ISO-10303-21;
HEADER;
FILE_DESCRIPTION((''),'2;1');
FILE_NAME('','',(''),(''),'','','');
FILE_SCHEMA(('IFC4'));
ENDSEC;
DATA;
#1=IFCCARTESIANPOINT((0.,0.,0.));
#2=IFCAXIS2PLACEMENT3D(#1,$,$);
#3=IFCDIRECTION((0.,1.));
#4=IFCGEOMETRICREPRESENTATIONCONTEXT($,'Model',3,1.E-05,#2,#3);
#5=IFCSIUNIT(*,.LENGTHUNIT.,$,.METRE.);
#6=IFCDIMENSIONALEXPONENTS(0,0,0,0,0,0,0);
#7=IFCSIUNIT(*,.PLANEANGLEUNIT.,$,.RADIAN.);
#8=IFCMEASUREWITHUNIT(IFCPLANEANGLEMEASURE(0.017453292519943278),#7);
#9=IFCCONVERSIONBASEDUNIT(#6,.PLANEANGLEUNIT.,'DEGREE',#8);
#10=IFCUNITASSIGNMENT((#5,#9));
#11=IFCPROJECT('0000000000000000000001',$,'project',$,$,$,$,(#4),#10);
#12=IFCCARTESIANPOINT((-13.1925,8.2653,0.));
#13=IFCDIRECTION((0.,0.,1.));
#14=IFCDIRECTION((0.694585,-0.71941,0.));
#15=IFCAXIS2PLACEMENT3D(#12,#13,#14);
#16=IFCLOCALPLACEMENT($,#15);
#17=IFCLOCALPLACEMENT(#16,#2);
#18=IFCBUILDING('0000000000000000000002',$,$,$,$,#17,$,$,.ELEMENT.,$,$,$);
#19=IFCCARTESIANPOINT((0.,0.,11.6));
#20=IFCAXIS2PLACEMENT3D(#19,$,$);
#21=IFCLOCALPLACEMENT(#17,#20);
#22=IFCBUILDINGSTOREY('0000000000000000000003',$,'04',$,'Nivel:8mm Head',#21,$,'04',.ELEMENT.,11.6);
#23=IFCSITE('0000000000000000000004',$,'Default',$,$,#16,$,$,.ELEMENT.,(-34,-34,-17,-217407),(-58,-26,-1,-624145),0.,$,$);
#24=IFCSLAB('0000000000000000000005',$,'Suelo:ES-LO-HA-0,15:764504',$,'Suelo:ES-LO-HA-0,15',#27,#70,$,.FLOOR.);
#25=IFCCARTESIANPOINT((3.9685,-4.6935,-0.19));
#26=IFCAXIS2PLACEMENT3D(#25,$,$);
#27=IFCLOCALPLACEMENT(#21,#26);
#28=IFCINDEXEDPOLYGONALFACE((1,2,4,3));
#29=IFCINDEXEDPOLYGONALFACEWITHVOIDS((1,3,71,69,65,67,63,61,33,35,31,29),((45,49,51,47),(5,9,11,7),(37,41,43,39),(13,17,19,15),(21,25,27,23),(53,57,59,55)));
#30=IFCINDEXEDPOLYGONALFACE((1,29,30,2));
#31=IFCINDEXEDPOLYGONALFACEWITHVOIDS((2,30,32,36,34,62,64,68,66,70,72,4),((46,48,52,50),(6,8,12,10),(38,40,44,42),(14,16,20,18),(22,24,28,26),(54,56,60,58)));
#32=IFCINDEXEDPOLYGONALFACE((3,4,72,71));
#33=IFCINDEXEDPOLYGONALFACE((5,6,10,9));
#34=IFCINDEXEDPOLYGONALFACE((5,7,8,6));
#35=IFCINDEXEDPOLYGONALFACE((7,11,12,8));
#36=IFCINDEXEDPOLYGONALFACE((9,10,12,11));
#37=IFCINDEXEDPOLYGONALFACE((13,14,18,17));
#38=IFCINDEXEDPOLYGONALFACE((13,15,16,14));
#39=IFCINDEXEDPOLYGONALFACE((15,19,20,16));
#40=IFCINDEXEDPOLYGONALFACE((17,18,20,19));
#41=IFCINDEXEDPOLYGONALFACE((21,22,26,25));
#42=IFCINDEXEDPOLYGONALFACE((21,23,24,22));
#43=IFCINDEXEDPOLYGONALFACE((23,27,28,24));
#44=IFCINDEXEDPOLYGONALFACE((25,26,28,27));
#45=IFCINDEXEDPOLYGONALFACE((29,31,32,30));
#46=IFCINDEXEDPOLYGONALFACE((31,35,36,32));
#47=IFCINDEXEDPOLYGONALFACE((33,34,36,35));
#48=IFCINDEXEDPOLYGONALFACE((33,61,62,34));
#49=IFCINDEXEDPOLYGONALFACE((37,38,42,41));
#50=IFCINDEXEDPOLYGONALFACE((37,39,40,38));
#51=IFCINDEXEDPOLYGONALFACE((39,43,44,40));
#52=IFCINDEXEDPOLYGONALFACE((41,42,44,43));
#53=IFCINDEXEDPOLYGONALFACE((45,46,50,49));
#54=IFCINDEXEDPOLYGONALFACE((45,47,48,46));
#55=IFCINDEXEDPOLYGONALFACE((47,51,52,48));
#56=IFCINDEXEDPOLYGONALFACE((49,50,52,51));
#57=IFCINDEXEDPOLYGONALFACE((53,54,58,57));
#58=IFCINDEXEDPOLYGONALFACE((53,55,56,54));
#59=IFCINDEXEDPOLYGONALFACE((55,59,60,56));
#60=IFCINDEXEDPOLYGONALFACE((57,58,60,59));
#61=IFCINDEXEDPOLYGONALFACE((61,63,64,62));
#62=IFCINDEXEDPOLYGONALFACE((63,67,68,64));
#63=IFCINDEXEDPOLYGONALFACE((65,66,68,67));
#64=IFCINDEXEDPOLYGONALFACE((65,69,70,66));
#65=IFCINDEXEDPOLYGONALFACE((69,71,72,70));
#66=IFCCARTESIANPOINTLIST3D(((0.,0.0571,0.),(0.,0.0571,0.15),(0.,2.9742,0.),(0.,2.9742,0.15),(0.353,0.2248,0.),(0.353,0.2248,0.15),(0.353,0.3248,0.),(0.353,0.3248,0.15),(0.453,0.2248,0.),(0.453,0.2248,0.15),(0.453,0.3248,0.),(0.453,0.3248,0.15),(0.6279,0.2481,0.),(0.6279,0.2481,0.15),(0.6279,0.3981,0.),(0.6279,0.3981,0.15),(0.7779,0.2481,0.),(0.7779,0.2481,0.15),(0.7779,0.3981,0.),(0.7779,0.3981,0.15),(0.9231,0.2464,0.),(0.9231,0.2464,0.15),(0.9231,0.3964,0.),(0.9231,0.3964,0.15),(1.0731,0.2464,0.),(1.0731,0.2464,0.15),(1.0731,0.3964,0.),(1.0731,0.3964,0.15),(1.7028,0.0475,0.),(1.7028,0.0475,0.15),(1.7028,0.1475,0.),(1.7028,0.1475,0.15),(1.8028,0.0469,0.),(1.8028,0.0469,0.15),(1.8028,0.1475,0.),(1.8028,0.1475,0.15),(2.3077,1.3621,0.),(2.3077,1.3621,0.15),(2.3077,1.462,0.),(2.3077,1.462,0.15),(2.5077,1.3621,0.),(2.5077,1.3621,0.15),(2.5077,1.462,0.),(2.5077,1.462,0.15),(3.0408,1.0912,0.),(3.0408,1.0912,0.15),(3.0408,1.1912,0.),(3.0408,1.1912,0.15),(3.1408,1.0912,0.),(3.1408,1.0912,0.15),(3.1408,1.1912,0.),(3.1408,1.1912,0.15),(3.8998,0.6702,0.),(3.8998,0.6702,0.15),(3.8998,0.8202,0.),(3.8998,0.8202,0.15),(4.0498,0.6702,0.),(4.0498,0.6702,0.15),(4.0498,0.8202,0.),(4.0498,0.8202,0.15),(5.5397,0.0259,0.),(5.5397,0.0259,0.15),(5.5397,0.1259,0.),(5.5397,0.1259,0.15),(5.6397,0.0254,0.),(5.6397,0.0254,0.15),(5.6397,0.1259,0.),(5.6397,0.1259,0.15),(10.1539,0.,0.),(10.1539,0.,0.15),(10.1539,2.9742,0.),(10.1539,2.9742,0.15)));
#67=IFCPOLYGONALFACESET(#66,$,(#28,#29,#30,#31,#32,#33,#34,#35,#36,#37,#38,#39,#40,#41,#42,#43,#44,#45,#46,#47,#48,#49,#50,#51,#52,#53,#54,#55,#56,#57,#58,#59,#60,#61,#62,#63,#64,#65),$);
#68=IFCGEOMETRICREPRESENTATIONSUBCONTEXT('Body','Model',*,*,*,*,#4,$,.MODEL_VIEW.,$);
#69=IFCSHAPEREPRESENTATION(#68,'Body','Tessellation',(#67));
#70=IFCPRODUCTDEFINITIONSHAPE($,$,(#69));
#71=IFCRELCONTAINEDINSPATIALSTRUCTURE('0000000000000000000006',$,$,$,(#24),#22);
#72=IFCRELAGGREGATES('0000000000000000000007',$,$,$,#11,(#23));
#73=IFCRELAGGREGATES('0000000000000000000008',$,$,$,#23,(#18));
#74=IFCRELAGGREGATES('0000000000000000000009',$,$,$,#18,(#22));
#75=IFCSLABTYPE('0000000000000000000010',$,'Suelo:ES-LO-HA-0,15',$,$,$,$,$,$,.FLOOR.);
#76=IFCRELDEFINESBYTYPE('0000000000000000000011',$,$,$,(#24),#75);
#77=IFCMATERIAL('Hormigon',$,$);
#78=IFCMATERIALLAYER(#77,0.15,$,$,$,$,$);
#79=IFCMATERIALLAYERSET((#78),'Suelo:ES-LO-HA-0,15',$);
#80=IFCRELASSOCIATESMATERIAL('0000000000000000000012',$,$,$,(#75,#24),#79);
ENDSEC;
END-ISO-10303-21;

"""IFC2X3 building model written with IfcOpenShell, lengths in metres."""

from ifc_helpers import new_model, entity, si_unit, converted_unit, direction, frame, frame_2d, origin, origin_2d_with_axis, place, context, subcontext, project, spatial, polyline, rectangle, outline, extrude, material, layer, layer_set, layer_usage, type_object, element, save


model = new_model("IFC2X3")

# Units and contexts
model_context = context("Model", 3, precision=1e-05, world=origin(), true_north=direction((0.0, 1.0)))
body_context = subcontext(model_context, "Body", "Model", "MODEL_VIEW")
ifc_project = project(units=[si_unit("LENGTHUNIT", "METRE"), converted_unit("PLANEANGLEUNIT", "DEGREE", entity("IfcPlaneAngleMeasure", 0.017453292519943278), si_unit("PLANEANGLEUNIT", "RADIAN"), dimensions=[0, 0, 0, 0, 0, 0, 0])], contexts=[model_context])

# Site, building, storey
site_placement = place(None, frame((-13.1925, 8.2653, 0.0), z_axis=(0.0, 0.0, 1.0), x_axis=(0.694585, -0.71941, 0.0)))
site = spatial("IfcSite", under=ifc_project, at=site_placement, Name="Default", CompositionType="ELEMENT", RefLatitude=(-34, -34, -17, -217407), RefLongitude=(-58, -26, -1, -624145), RefElevation=0.0)
building_placement = place(site_placement, origin())
building = spatial("IfcBuilding", under=site, at=building_placement, CompositionType="ELEMENT")
storey_placement = place(building_placement, frame((0.0, 0.0, 11.6)))
storey = spatial("IfcBuildingStorey", under=building, at=storey_placement, Name="04", ObjectType="Nivel:8mm Head", LongName="04", CompositionType="ELEMENT", Elevation=11.6)

# Shared definitions
ifc_material_1 = material(Name="Hormigon")

# Slab, openings
ifc_layer = layer(ifc_material_1, 0.15)
ifc_layer_set = layer_set([ifc_layer], Name="Suelo:ES-LO-HA-0,15")
ifc_layer_usage = layer_usage(ifc_layer_set, "AXIS3", "POSITIVE", 0.0)
slab_type = type_object("IfcSlabType", Name="Suelo:ES-LO-HA-0,15", PredefinedType="FLOOR", material=ifc_layer_set)
slab_placement = place(storey_placement, frame((3.9685, -4.6935, -0.19)))
slab = element("IfcSlab", 1, at=slab_placement, inside=storey, type_object=slab_type, material=ifc_layer_usage, Name="Suelo:ES-LO-HA-0,15:764504", ObjectType="Suelo:ES-LO-HA-0,15", PredefinedType="FLOOR", context=body_context, shape_type="SweptSolid", body=[
    extrude(outline(polyline([(-5.077, 1.4871), (-5.077, -1.4871), (-0.5627, -1.4617), (-0.5627, -1.3612), (-0.4627, -1.3612), (-0.4627, -1.4612), (3.2742, -1.4402), (3.2742, -1.3396), (3.3742, -1.3396), (3.3742, -1.4396), (5.077, -1.43), (5.077, 1.4871), (-5.077, 1.4871)])), frame((5.077, 1.4871, 0.15), z_axis=(0.0, 0.0, -1.0), x_axis=(-1.0, 0.0, 0.0)), (0.0, 0.0, 1.0), 0.15),
])
opening_1_placement = place(slab_placement, origin())
element("IfcOpeningElement", 2, at=opening_1_placement, cuts=slab, ObjectType="Opening", context=body_context, shape_type="SweptSolid", body=[
    extrude(rectangle(XDim=0.1, YDim=0.2, at=origin_2d_with_axis()), frame((2.4077, 1.412, 0.15), z_axis=(0.0, 0.0, -1.0), x_axis=(0.0, -1.0, 0.0)), (0.0, 0.0, 1.0), 0.15),
])
opening_2_placement = place(slab_placement, origin())
element("IfcOpeningElement", 3, at=opening_2_placement, cuts=slab, ObjectType="Opening", context=body_context, shape_type="SweptSolid", body=[
    extrude(rectangle(XDim=0.1, YDim=0.1, at=frame_2d((0.0, 0.0), x_axis=(1.0, 0.0))), frame((3.0908, 1.1412, 0.15), z_axis=(0.0, 0.0, -1.0), x_axis=(0.0, -1.0, 0.0)), (0.0, 0.0, 1.0), 0.15),
])
opening_3_placement = place(slab_placement, origin())
element("IfcOpeningElement", 4, at=opening_3_placement, cuts=slab, ObjectType="Opening", context=body_context, shape_type="SweptSolid", body=[
    extrude(rectangle(XDim=0.15, YDim=0.15, at=frame_2d((0.0, 0.0), x_axis=(1.0, 0.0))), frame((3.9748, 0.7452, 0.15), z_axis=(0.0, 0.0, -1.0), x_axis=(0.0, -1.0, 0.0)), (0.0, 0.0, 1.0), 0.15),
])
opening_4_placement = place(slab_placement, origin())
element("IfcOpeningElement", 5, at=opening_4_placement, cuts=slab, ObjectType="Opening", context=body_context, shape_type="SweptSolid", body=[
    extrude(rectangle(XDim=0.15, YDim=0.15, at=frame_2d((0.0, 0.0), x_axis=(1.0, 0.0))), frame((0.9981, 0.3214, 0.15), z_axis=(0.0, 0.0, -1.0), x_axis=(0.0, -1.0, 0.0)), (0.0, 0.0, 1.0), 0.15),
])
opening_5_placement = place(slab_placement, origin())
element("IfcOpeningElement", 6, at=opening_5_placement, cuts=slab, ObjectType="Opening", context=body_context, shape_type="SweptSolid", body=[
    extrude(rectangle(XDim=0.15, YDim=0.15, at=frame_2d((0.0, 0.0), x_axis=(1.0, 0.0))), frame((0.7029, 0.3231, 0.15), z_axis=(0.0, 0.0, 1.0), x_axis=(0.0, -1.0, 0.0)), (0.0, 0.0, -1.0), 0.15),
])
opening_6_placement = place(slab_placement, origin())
element("IfcOpeningElement", 7, at=opening_6_placement, cuts=slab, ObjectType="Opening", context=body_context, shape_type="SweptSolid", body=[
    extrude(rectangle(XDim=0.1, YDim=0.1, at=frame_2d((0.0, 0.0), x_axis=(1.0, 0.0))), frame((0.403, 0.2748, 0.15), z_axis=(0.0, 0.0, -1.0), x_axis=(0.0, -1.0, 0.0)), (0.0, 0.0, 1.0), 0.15),
])

save(model, "model.ifc")
